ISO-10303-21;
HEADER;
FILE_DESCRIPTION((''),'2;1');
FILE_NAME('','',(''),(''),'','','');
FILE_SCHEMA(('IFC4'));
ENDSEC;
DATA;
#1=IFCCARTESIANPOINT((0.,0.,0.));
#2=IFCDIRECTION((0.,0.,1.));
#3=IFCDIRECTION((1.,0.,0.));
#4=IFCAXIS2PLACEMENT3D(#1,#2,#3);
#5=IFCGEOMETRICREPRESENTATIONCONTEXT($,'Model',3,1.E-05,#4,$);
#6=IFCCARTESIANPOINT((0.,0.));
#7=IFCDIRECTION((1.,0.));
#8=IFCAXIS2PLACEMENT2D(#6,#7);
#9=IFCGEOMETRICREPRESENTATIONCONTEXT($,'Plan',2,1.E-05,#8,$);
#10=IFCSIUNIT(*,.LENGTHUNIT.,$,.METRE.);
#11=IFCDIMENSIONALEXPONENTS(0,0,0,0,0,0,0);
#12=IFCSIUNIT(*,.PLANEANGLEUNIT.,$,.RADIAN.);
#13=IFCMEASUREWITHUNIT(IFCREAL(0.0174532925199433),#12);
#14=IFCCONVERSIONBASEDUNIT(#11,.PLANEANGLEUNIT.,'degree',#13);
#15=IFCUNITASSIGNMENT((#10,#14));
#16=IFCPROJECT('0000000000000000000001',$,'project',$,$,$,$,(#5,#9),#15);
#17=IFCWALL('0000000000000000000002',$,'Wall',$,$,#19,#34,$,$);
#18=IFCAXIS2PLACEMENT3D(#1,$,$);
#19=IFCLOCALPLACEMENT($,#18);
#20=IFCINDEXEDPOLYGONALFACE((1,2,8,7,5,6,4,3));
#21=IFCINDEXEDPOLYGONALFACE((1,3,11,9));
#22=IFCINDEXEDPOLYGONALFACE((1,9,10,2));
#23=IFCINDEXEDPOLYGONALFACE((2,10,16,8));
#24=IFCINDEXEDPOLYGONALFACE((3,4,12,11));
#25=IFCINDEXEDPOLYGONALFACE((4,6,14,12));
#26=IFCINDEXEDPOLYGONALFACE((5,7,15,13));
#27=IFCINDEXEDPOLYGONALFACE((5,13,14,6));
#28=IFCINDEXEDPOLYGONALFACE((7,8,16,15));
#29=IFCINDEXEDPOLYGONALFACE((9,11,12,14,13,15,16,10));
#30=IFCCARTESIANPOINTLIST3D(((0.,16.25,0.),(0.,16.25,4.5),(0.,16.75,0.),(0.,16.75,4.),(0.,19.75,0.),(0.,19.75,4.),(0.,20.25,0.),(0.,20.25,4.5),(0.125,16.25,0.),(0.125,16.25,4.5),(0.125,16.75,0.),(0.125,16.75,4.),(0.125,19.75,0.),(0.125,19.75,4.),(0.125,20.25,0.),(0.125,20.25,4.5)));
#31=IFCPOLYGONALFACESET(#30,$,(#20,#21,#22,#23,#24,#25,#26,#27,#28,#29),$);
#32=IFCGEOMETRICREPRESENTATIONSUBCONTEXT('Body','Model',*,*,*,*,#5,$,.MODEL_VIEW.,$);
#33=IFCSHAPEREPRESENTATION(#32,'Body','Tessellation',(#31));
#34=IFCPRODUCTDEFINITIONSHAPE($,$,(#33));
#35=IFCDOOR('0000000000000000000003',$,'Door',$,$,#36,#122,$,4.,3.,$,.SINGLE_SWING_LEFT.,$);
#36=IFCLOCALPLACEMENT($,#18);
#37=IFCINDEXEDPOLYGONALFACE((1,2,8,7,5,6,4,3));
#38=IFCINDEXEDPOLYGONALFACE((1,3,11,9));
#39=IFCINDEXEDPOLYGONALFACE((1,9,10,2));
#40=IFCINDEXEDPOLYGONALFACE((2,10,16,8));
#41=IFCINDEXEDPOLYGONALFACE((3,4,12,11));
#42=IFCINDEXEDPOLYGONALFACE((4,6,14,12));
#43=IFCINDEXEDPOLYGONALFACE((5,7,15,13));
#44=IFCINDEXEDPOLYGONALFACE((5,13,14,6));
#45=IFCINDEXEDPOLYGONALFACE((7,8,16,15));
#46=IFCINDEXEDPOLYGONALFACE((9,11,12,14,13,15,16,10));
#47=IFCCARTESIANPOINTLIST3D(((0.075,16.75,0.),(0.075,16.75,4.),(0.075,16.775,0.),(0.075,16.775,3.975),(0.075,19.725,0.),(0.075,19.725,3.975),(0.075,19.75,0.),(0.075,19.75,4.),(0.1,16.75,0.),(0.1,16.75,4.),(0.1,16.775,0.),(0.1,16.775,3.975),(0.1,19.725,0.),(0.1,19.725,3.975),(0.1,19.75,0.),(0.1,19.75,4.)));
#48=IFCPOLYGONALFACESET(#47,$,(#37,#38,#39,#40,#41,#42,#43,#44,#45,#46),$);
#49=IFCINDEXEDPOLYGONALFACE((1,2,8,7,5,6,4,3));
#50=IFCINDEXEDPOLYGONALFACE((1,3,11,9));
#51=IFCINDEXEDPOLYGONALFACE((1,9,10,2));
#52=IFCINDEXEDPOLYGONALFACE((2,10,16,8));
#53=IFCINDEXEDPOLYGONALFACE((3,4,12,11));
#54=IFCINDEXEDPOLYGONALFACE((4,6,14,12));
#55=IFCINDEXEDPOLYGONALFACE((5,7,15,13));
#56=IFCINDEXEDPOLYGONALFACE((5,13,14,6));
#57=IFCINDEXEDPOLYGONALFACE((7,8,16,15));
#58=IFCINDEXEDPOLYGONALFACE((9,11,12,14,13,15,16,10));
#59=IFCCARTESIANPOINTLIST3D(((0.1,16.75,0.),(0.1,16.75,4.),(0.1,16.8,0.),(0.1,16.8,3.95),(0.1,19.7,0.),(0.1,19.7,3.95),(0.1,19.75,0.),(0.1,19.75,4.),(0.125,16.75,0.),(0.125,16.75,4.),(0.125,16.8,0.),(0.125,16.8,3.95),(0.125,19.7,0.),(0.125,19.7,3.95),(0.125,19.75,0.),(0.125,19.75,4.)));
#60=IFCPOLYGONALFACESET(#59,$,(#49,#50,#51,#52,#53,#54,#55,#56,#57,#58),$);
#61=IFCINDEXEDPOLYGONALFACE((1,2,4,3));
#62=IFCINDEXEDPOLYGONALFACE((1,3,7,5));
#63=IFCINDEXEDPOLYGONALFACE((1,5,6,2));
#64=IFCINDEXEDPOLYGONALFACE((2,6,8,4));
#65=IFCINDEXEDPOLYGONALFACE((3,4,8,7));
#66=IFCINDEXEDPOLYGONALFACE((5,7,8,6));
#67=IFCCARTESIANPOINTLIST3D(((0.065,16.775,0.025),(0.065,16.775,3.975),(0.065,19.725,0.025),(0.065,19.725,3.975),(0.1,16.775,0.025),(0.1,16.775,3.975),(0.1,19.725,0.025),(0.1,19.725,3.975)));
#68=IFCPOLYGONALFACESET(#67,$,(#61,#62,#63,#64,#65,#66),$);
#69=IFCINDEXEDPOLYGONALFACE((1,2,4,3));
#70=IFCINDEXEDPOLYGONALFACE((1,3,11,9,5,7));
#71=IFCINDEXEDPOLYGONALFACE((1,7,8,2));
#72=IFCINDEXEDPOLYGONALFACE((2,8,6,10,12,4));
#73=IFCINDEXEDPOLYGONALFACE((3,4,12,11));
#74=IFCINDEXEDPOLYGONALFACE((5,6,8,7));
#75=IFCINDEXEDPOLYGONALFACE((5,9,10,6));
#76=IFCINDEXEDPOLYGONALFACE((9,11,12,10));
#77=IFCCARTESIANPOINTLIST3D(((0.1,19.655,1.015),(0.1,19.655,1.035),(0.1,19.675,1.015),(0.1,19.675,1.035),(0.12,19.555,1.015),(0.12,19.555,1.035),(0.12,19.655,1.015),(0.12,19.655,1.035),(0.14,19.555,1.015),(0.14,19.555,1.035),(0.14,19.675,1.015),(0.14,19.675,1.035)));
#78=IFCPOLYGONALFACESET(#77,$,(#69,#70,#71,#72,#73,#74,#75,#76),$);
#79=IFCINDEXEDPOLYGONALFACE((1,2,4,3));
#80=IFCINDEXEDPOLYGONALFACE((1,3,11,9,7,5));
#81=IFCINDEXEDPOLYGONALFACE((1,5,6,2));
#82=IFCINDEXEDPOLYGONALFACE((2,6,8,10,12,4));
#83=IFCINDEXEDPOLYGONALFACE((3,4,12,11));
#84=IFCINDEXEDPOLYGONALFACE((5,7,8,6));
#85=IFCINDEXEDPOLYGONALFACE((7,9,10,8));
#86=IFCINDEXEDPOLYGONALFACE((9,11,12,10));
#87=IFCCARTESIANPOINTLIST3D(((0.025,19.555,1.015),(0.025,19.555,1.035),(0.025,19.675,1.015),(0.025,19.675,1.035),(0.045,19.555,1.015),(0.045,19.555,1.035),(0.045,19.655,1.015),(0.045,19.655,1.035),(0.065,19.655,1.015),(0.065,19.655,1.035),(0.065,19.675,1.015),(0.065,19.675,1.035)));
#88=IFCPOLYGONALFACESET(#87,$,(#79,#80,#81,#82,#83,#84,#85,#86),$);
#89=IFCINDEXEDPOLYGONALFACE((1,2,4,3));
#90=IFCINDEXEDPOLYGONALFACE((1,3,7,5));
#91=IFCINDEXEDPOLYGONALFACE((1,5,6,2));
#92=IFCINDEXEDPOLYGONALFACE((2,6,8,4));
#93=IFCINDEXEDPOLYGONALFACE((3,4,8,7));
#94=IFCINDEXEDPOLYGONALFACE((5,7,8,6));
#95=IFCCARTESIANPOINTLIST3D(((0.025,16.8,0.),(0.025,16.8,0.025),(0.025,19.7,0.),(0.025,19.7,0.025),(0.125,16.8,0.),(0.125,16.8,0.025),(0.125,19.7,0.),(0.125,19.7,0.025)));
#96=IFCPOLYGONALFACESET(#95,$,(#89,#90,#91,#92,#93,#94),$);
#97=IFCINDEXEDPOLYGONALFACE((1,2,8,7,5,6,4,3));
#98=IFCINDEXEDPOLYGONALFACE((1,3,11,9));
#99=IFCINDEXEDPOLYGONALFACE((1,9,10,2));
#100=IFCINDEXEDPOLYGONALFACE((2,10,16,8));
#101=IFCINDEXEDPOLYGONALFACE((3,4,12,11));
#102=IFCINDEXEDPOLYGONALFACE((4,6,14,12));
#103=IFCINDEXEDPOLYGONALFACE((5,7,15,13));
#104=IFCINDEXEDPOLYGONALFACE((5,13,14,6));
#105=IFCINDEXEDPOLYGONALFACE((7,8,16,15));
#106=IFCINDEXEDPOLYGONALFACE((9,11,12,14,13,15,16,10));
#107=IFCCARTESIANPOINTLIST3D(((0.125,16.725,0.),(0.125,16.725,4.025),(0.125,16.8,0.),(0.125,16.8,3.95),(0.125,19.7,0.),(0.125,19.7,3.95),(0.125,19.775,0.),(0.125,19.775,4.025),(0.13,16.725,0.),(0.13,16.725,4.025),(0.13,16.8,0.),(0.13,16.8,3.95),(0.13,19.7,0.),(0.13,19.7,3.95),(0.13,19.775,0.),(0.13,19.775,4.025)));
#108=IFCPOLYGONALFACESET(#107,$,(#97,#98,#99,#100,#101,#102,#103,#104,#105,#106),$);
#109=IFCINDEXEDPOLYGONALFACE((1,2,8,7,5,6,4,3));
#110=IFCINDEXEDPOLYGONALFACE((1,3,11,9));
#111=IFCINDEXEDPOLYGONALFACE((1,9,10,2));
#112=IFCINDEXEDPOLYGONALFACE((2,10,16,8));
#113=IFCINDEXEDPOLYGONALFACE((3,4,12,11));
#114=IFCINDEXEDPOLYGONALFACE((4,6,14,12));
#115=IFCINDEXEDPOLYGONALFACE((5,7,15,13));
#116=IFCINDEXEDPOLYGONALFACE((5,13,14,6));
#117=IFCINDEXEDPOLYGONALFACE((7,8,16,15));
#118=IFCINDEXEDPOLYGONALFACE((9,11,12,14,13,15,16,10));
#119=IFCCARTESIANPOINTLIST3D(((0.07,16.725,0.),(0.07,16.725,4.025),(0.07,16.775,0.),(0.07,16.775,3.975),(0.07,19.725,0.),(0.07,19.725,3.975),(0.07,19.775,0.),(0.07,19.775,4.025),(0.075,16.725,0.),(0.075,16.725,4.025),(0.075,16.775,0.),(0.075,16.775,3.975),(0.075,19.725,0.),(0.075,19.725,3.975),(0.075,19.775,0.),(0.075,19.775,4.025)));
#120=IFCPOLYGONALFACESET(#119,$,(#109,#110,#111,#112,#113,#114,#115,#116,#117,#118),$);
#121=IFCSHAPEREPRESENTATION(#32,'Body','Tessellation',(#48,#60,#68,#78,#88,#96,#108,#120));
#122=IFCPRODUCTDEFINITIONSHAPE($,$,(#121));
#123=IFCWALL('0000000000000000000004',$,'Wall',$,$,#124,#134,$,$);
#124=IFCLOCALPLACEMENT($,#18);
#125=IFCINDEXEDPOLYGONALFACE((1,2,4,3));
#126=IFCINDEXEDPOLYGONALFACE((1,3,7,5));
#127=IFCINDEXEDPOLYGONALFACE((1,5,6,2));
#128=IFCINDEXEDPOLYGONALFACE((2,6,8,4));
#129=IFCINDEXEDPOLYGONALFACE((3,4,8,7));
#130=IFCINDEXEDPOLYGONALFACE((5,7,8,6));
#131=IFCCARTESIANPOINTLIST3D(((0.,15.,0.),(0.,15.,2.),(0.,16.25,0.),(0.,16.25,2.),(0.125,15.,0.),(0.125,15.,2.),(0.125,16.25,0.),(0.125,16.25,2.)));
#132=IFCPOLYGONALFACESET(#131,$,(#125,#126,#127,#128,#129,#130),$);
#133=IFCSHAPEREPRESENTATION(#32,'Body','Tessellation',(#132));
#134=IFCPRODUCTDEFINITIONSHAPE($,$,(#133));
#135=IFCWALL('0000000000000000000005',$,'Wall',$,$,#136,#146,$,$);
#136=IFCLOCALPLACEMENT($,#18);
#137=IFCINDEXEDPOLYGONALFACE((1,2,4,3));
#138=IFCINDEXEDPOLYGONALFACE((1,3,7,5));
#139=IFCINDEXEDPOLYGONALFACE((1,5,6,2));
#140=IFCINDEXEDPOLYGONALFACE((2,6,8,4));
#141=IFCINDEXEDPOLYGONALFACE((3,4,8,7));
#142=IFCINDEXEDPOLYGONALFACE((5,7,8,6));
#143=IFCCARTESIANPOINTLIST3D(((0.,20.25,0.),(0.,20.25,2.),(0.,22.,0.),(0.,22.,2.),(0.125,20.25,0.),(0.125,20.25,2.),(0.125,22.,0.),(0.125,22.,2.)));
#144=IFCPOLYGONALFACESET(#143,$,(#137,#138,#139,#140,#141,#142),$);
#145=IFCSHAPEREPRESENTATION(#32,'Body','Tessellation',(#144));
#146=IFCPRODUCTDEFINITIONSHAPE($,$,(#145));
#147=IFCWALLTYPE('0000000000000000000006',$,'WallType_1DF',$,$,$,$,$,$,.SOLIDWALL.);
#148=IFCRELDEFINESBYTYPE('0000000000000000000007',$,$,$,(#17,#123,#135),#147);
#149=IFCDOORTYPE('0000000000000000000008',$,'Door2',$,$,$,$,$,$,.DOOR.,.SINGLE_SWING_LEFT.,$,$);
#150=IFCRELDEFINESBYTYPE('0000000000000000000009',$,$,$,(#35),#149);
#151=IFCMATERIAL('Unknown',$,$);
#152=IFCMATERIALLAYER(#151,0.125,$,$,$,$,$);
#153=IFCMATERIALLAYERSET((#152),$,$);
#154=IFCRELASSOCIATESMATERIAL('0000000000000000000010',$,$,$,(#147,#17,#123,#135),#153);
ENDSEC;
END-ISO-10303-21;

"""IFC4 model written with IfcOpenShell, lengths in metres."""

from ifc_helpers import new_model, entity, si_unit, converted_unit, frame, origin_with_axes, origin_2d_with_axis, place, context, subcontext, project, line, indexed_curve, outline, extrude, shape, source, transform, mapped, material, layer, layer_set, layer_usage, type_object, type_shapes, element, fill, save


model = new_model("IFC4")

# Units and contexts
model_context = context("Model", 3, precision=1e-05, world=origin_with_axes())
plan_context = context("Plan", 2, precision=1e-05, world=origin_2d_with_axis())
body_context_1 = subcontext(model_context, "Body", "Model", "MODEL_VIEW")
body_context_2 = subcontext(plan_context, "Body", "Plan", "PLAN_VIEW")
ifc_project = project(units=[si_unit("LENGTHUNIT", "METRE"), converted_unit("PLANEANGLEUNIT", "degree", entity("IfcReal", 0.0174532925199433), si_unit("PLANEANGLEUNIT", "RADIAN"), dimensions=[0, 0, 0, 0, 0, 0, 0])], contexts=[model_context, plan_context])

# Shared definitions
ifc_material = material(Name="Unknown")
ifc_layer_1 = layer(ifc_material, 0.125)
ifc_layer_set_1 = layer_set([ifc_layer_1])
wall_type_1 = type_object("IfcWallType", Name="WallType_1DF", PredefinedType="SOLIDWALL", material=ifc_layer_set_1)

# Wall, opening, door
ifc_layer_usage_1 = layer_usage(ifc_layer_set_1, "AXIS2", "POSITIVE", 0.0)
wall_1_placement = place(None, frame((0.125, 16.25, 0.0), z_axis=(0.0, 0.0, 1.0), x_axis=(0.0, 1.0, 0.0)))
wall_1 = element("IfcWall", 1, at=wall_1_placement, type_object=wall_type_1, material=ifc_layer_usage_1, Name="Wall", context=body_context_1, shape_type="SweptSolid", body=[
    extrude(outline(indexed_curve([(0.0, 0.0), (0.0, 0.125), (4.0, 0.125), (4.0, 0.0), (0.0, 0.0)], self_intersect=False)), origin_with_axes(), (0.0, 0.0, 1.0), 4.5),
])
shared_shape_1 = source(origin_with_axes(), body_context_1, "Body", "SweptSolid", [
    extrude(outline(indexed_curve([(0.0, 0.0), (3.0, 0.0), (3.0, 4.0), (0.0, 4.0)], segments=[line(1, 2, 3, 4, 1)])), frame((0.0, -0.1, 0.0), z_axis=(0.0, -1.0, 0.0), x_axis=(1.0, 0.0, 0.0)), (0.0, 0.0, -1.0), 0.45),
])
opening_placement = place(wall_1_placement, frame((0.5, 0.0, 0.0), z_axis=(0.0, 0.0, 1.0), x_axis=(1.0, 0.0, 0.0)))
opening = element("IfcOpeningElement", 2, at=opening_placement, cuts=wall_1, PredefinedType="OPENING", context=body_context_1, shape_type="MappedRepresentation", body=[
    mapped(shared_shape_1, transform((0.0, 0.0, 0.0), x_axis=(1.0, 0.0, 0.0), y_axis=(0.0, 1.0, 0.0), z_axis=(0.0, 0.0, 1.0), scale=1.0)),
])
door_type = type_object("IfcDoorType", Name="Door2", OperationType="SINGLE_SWING_LEFT", PredefinedType="DOOR")
shared_shape_2 = source(origin_with_axes(), body_context_1, "Body", "SweptSolid", [
    extrude(outline(indexed_curve([(0.0, 0.0), (0.0, 4.0), (3.0, 4.0), (3.0, 0.0), (2.975, 0.0), (2.975, 3.975), (0.025, 3.975), (0.025, 0.0)], segments=[line(1, 2, 3, 4, 5, 6, 7, 8, 1)])), frame((0.0, 0.025, 0.0), z_axis=(0.0, -1.0, 0.0), x_axis=(1.0, 0.0, 0.0)), (0.0, 0.0, -1.0), 0.025),
    extrude(outline(indexed_curve([(0.0, 0.0), (0.0, 4.0), (3.0, 4.0), (3.0, 0.0), (2.95, 0.0), (2.95, 3.95), (0.05, 3.95), (0.05, 0.0)], segments=[line(1, 2, 3, 4, 5, 6, 7, 8, 1)])), frame((0.0, 0.0, 0.0), z_axis=(0.0, -1.0, 0.0), x_axis=(1.0, 0.0, 0.0)), (0.0, 0.0, -1.0), 0.025),
    extrude(outline(indexed_curve([(0.0, 0.0), (2.95, 0.0), (2.95, 0.035), (0.0, 0.035)], segments=[line(1, 2, 3, 4, 1)])), frame((0.025, 0.025, 0.025), z_axis=(0.0, 0.0, 1.0), x_axis=(1.0, 0.0, 0.0)), (0.0, 0.0, 1.0), 3.95),
    extrude(outline(indexed_curve([(0.0, 0.0), (0.0, -0.04), (-0.12, -0.04), (-0.12, -0.02), (-0.02, -0.02), (-0.02, 0.0)], segments=[line(1, 2, 3, 4, 5, 6, 1)])), frame((2.925, 0.025, 1.015), z_axis=(0.0, 0.0, 1.0), x_axis=(1.0, 0.0, 0.0)), (0.0, 0.0, 1.0), 0.02),
    extrude(outline(indexed_curve([(0.0, 0.0), (0.0, 0.04), (-0.12, 0.04), (-0.12, 0.02), (-0.02, 0.02), (-0.02, 0.0)], segments=[line(1, 2, 3, 4, 5, 6, 1)])), frame((2.925, 0.06, 1.015), z_axis=(0.0, 0.0, 1.0), x_axis=(1.0, 0.0, 0.0)), (0.0, 0.0, 1.0), 0.02),
    extrude(outline(indexed_curve([(0.0, 0.0), (2.9, 0.0), (2.9, 0.1), (0.0, 0.1)], segments=[line(1, 2, 3, 4, 1)])), frame((0.05, 0.0, 0.0), z_axis=(0.0, 0.0, 1.0), x_axis=(1.0, 0.0, 0.0)), (0.0, 0.0, 1.0), 0.025),
    extrude(outline(indexed_curve([(0.0, 0.0), (0.0, 4.025), (3.05, 4.025), (3.05, 0.0), (2.975, 0.0), (2.975, 3.95), (0.075, 3.95), (0.075, 0.0)], segments=[line(1, 2, 3, 4, 5, 6, 7, 8, 1)])), frame((-0.025, -0.005, 0.0), z_axis=(0.0, -1.0, 0.0), x_axis=(1.0, 0.0, 0.0)), (0.0, 0.0, -1.0), 0.005),
    extrude(outline(indexed_curve([(0.0, 0.0), (0.0, 4.025), (3.05, 4.025), (3.05, 0.0), (3.0, 0.0), (3.0, 3.975), (0.05, 3.975), (0.05, 0.0)], segments=[line(1, 2, 3, 4, 5, 6, 7, 8, 1)])), frame((-0.025, 0.05, 0.0), z_axis=(0.0, -1.0, 0.0), x_axis=(1.0, 0.0, 0.0)), (0.0, 0.0, -1.0), 0.005),
])
shared_shape_3 = source(origin_with_axes(), body_context_2, "Body", "Curve2D", [
    entity("IfcIndexedPolyCurve", entity("IfcCartesianPointList2D", [[0.0, 0.0], [0.0, 0.05], [0.025, 0.05], [0.025, 0.025], [0.05, 0.025], [0.05, 0.0]]), [entity("IfcLineIndex", [1, 2, 3, 4, 5, 6, 1])]),
    entity("IfcIndexedPolyCurve", entity("IfcCartesianPointList2D", [[3.0, 0.0], [3.0, 0.05], [2.975, 0.05], [2.975, 0.025], [2.95, 0.025], [2.95, 0.0]]), [entity("IfcLineIndex", [1, 2, 3, 4, 5, 6, 1])]),
    entity("IfcTrimmedCurve", entity("IfcEllipse", entity("IfcAxis2Placement2D", entity("IfcCartesianPoint", [0.06, 0.05]), entity("IfcDirection", [1.0, 0.0])), 2.915, 2.95), [entity("IfcCartesianPoint", [2.975, 0.05])], [entity("IfcCartesianPoint", [0.06, 3.0])], True, "CARTESIAN"),
    entity("IfcIndexedPolyCurve", entity("IfcCartesianPointList2D", [[0.025, 0.05], [0.06, 0.05], [0.06, 3.0], [0.025, 3.0]]), [entity("IfcLineIndex", [1, 2, 3, 4, 1])]),
])
type_shapes(door_type, [shared_shape_2, shared_shape_3])
door_placement = place(opening_placement, frame((0.0, 0.0, 0.0), z_axis=(0.0, 0.0, 1.0), x_axis=(1.0, 0.0, 0.0)))
door = element("IfcDoor", 3, at=door_placement, type_object=door_type, Name="Door", OperationType="SINGLE_SWING_LEFT", OverallHeight=4.0, OverallWidth=3.0, shapes=[
    shape(body_context_1, "Body", "MappedRepresentation", [mapped(shared_shape_2, transform((0.0, 0.0, 0.0), x_axis=(1.0, 0.0, 0.0), y_axis=(0.0, 1.0, 0.0), z_axis=(0.0, 0.0, 1.0), scale=1.0))]),
    shape(body_context_2, "Body", "MappedRepresentation", [mapped(shared_shape_3, transform((0.0, 0.0, 0.0), x_axis=(1.0, 0.0, 0.0), y_axis=(0.0, 1.0, 0.0), z_axis=(0.0, 0.0, 1.0), scale=1.0))]),
])
fill(opening, door)

# Walls
ifc_layer_usage_2 = layer_usage(ifc_layer_set_1, "AXIS2", "POSITIVE", 0.0)
wall_2_placement = place(None, frame((0.125, 15.0, 0.0), z_axis=(0.0, 0.0, 1.0), x_axis=(0.0, 1.0, 0.0)))
element("IfcWall", 4, at=wall_2_placement, type_object=wall_type_1, material=ifc_layer_usage_2, Name="Wall", context=body_context_1, shape_type="SweptSolid", body=[
    extrude(outline(indexed_curve([(0.0, 0.0), (0.0, 0.125), (1.25, 0.125), (1.25, 0.0), (0.0, 0.0)], self_intersect=False)), origin_with_axes(), (0.0, 0.0, 1.0), 2.0),
])
ifc_layer_usage_3 = layer_usage(ifc_layer_set_1, "AXIS2", "POSITIVE", 0.0)
wall_3_placement = place(None, frame((0.125, 20.25, 0.0), z_axis=(0.0, 0.0, 1.0), x_axis=(0.0, 1.0, 0.0)))
element("IfcWall", 5, at=wall_3_placement, type_object=wall_type_1, material=ifc_layer_usage_3, Name="Wall", context=body_context_1, shape_type="SweptSolid", body=[
    extrude(outline(indexed_curve([(0.0, 0.0), (0.0, 0.125), (1.75, 0.125), (1.75, 0.0), (0.0, 0.0)], self_intersect=False)), origin_with_axes(), (0.0, 0.0, 1.0), 2.0),
])

save(model, "model.ifc")
